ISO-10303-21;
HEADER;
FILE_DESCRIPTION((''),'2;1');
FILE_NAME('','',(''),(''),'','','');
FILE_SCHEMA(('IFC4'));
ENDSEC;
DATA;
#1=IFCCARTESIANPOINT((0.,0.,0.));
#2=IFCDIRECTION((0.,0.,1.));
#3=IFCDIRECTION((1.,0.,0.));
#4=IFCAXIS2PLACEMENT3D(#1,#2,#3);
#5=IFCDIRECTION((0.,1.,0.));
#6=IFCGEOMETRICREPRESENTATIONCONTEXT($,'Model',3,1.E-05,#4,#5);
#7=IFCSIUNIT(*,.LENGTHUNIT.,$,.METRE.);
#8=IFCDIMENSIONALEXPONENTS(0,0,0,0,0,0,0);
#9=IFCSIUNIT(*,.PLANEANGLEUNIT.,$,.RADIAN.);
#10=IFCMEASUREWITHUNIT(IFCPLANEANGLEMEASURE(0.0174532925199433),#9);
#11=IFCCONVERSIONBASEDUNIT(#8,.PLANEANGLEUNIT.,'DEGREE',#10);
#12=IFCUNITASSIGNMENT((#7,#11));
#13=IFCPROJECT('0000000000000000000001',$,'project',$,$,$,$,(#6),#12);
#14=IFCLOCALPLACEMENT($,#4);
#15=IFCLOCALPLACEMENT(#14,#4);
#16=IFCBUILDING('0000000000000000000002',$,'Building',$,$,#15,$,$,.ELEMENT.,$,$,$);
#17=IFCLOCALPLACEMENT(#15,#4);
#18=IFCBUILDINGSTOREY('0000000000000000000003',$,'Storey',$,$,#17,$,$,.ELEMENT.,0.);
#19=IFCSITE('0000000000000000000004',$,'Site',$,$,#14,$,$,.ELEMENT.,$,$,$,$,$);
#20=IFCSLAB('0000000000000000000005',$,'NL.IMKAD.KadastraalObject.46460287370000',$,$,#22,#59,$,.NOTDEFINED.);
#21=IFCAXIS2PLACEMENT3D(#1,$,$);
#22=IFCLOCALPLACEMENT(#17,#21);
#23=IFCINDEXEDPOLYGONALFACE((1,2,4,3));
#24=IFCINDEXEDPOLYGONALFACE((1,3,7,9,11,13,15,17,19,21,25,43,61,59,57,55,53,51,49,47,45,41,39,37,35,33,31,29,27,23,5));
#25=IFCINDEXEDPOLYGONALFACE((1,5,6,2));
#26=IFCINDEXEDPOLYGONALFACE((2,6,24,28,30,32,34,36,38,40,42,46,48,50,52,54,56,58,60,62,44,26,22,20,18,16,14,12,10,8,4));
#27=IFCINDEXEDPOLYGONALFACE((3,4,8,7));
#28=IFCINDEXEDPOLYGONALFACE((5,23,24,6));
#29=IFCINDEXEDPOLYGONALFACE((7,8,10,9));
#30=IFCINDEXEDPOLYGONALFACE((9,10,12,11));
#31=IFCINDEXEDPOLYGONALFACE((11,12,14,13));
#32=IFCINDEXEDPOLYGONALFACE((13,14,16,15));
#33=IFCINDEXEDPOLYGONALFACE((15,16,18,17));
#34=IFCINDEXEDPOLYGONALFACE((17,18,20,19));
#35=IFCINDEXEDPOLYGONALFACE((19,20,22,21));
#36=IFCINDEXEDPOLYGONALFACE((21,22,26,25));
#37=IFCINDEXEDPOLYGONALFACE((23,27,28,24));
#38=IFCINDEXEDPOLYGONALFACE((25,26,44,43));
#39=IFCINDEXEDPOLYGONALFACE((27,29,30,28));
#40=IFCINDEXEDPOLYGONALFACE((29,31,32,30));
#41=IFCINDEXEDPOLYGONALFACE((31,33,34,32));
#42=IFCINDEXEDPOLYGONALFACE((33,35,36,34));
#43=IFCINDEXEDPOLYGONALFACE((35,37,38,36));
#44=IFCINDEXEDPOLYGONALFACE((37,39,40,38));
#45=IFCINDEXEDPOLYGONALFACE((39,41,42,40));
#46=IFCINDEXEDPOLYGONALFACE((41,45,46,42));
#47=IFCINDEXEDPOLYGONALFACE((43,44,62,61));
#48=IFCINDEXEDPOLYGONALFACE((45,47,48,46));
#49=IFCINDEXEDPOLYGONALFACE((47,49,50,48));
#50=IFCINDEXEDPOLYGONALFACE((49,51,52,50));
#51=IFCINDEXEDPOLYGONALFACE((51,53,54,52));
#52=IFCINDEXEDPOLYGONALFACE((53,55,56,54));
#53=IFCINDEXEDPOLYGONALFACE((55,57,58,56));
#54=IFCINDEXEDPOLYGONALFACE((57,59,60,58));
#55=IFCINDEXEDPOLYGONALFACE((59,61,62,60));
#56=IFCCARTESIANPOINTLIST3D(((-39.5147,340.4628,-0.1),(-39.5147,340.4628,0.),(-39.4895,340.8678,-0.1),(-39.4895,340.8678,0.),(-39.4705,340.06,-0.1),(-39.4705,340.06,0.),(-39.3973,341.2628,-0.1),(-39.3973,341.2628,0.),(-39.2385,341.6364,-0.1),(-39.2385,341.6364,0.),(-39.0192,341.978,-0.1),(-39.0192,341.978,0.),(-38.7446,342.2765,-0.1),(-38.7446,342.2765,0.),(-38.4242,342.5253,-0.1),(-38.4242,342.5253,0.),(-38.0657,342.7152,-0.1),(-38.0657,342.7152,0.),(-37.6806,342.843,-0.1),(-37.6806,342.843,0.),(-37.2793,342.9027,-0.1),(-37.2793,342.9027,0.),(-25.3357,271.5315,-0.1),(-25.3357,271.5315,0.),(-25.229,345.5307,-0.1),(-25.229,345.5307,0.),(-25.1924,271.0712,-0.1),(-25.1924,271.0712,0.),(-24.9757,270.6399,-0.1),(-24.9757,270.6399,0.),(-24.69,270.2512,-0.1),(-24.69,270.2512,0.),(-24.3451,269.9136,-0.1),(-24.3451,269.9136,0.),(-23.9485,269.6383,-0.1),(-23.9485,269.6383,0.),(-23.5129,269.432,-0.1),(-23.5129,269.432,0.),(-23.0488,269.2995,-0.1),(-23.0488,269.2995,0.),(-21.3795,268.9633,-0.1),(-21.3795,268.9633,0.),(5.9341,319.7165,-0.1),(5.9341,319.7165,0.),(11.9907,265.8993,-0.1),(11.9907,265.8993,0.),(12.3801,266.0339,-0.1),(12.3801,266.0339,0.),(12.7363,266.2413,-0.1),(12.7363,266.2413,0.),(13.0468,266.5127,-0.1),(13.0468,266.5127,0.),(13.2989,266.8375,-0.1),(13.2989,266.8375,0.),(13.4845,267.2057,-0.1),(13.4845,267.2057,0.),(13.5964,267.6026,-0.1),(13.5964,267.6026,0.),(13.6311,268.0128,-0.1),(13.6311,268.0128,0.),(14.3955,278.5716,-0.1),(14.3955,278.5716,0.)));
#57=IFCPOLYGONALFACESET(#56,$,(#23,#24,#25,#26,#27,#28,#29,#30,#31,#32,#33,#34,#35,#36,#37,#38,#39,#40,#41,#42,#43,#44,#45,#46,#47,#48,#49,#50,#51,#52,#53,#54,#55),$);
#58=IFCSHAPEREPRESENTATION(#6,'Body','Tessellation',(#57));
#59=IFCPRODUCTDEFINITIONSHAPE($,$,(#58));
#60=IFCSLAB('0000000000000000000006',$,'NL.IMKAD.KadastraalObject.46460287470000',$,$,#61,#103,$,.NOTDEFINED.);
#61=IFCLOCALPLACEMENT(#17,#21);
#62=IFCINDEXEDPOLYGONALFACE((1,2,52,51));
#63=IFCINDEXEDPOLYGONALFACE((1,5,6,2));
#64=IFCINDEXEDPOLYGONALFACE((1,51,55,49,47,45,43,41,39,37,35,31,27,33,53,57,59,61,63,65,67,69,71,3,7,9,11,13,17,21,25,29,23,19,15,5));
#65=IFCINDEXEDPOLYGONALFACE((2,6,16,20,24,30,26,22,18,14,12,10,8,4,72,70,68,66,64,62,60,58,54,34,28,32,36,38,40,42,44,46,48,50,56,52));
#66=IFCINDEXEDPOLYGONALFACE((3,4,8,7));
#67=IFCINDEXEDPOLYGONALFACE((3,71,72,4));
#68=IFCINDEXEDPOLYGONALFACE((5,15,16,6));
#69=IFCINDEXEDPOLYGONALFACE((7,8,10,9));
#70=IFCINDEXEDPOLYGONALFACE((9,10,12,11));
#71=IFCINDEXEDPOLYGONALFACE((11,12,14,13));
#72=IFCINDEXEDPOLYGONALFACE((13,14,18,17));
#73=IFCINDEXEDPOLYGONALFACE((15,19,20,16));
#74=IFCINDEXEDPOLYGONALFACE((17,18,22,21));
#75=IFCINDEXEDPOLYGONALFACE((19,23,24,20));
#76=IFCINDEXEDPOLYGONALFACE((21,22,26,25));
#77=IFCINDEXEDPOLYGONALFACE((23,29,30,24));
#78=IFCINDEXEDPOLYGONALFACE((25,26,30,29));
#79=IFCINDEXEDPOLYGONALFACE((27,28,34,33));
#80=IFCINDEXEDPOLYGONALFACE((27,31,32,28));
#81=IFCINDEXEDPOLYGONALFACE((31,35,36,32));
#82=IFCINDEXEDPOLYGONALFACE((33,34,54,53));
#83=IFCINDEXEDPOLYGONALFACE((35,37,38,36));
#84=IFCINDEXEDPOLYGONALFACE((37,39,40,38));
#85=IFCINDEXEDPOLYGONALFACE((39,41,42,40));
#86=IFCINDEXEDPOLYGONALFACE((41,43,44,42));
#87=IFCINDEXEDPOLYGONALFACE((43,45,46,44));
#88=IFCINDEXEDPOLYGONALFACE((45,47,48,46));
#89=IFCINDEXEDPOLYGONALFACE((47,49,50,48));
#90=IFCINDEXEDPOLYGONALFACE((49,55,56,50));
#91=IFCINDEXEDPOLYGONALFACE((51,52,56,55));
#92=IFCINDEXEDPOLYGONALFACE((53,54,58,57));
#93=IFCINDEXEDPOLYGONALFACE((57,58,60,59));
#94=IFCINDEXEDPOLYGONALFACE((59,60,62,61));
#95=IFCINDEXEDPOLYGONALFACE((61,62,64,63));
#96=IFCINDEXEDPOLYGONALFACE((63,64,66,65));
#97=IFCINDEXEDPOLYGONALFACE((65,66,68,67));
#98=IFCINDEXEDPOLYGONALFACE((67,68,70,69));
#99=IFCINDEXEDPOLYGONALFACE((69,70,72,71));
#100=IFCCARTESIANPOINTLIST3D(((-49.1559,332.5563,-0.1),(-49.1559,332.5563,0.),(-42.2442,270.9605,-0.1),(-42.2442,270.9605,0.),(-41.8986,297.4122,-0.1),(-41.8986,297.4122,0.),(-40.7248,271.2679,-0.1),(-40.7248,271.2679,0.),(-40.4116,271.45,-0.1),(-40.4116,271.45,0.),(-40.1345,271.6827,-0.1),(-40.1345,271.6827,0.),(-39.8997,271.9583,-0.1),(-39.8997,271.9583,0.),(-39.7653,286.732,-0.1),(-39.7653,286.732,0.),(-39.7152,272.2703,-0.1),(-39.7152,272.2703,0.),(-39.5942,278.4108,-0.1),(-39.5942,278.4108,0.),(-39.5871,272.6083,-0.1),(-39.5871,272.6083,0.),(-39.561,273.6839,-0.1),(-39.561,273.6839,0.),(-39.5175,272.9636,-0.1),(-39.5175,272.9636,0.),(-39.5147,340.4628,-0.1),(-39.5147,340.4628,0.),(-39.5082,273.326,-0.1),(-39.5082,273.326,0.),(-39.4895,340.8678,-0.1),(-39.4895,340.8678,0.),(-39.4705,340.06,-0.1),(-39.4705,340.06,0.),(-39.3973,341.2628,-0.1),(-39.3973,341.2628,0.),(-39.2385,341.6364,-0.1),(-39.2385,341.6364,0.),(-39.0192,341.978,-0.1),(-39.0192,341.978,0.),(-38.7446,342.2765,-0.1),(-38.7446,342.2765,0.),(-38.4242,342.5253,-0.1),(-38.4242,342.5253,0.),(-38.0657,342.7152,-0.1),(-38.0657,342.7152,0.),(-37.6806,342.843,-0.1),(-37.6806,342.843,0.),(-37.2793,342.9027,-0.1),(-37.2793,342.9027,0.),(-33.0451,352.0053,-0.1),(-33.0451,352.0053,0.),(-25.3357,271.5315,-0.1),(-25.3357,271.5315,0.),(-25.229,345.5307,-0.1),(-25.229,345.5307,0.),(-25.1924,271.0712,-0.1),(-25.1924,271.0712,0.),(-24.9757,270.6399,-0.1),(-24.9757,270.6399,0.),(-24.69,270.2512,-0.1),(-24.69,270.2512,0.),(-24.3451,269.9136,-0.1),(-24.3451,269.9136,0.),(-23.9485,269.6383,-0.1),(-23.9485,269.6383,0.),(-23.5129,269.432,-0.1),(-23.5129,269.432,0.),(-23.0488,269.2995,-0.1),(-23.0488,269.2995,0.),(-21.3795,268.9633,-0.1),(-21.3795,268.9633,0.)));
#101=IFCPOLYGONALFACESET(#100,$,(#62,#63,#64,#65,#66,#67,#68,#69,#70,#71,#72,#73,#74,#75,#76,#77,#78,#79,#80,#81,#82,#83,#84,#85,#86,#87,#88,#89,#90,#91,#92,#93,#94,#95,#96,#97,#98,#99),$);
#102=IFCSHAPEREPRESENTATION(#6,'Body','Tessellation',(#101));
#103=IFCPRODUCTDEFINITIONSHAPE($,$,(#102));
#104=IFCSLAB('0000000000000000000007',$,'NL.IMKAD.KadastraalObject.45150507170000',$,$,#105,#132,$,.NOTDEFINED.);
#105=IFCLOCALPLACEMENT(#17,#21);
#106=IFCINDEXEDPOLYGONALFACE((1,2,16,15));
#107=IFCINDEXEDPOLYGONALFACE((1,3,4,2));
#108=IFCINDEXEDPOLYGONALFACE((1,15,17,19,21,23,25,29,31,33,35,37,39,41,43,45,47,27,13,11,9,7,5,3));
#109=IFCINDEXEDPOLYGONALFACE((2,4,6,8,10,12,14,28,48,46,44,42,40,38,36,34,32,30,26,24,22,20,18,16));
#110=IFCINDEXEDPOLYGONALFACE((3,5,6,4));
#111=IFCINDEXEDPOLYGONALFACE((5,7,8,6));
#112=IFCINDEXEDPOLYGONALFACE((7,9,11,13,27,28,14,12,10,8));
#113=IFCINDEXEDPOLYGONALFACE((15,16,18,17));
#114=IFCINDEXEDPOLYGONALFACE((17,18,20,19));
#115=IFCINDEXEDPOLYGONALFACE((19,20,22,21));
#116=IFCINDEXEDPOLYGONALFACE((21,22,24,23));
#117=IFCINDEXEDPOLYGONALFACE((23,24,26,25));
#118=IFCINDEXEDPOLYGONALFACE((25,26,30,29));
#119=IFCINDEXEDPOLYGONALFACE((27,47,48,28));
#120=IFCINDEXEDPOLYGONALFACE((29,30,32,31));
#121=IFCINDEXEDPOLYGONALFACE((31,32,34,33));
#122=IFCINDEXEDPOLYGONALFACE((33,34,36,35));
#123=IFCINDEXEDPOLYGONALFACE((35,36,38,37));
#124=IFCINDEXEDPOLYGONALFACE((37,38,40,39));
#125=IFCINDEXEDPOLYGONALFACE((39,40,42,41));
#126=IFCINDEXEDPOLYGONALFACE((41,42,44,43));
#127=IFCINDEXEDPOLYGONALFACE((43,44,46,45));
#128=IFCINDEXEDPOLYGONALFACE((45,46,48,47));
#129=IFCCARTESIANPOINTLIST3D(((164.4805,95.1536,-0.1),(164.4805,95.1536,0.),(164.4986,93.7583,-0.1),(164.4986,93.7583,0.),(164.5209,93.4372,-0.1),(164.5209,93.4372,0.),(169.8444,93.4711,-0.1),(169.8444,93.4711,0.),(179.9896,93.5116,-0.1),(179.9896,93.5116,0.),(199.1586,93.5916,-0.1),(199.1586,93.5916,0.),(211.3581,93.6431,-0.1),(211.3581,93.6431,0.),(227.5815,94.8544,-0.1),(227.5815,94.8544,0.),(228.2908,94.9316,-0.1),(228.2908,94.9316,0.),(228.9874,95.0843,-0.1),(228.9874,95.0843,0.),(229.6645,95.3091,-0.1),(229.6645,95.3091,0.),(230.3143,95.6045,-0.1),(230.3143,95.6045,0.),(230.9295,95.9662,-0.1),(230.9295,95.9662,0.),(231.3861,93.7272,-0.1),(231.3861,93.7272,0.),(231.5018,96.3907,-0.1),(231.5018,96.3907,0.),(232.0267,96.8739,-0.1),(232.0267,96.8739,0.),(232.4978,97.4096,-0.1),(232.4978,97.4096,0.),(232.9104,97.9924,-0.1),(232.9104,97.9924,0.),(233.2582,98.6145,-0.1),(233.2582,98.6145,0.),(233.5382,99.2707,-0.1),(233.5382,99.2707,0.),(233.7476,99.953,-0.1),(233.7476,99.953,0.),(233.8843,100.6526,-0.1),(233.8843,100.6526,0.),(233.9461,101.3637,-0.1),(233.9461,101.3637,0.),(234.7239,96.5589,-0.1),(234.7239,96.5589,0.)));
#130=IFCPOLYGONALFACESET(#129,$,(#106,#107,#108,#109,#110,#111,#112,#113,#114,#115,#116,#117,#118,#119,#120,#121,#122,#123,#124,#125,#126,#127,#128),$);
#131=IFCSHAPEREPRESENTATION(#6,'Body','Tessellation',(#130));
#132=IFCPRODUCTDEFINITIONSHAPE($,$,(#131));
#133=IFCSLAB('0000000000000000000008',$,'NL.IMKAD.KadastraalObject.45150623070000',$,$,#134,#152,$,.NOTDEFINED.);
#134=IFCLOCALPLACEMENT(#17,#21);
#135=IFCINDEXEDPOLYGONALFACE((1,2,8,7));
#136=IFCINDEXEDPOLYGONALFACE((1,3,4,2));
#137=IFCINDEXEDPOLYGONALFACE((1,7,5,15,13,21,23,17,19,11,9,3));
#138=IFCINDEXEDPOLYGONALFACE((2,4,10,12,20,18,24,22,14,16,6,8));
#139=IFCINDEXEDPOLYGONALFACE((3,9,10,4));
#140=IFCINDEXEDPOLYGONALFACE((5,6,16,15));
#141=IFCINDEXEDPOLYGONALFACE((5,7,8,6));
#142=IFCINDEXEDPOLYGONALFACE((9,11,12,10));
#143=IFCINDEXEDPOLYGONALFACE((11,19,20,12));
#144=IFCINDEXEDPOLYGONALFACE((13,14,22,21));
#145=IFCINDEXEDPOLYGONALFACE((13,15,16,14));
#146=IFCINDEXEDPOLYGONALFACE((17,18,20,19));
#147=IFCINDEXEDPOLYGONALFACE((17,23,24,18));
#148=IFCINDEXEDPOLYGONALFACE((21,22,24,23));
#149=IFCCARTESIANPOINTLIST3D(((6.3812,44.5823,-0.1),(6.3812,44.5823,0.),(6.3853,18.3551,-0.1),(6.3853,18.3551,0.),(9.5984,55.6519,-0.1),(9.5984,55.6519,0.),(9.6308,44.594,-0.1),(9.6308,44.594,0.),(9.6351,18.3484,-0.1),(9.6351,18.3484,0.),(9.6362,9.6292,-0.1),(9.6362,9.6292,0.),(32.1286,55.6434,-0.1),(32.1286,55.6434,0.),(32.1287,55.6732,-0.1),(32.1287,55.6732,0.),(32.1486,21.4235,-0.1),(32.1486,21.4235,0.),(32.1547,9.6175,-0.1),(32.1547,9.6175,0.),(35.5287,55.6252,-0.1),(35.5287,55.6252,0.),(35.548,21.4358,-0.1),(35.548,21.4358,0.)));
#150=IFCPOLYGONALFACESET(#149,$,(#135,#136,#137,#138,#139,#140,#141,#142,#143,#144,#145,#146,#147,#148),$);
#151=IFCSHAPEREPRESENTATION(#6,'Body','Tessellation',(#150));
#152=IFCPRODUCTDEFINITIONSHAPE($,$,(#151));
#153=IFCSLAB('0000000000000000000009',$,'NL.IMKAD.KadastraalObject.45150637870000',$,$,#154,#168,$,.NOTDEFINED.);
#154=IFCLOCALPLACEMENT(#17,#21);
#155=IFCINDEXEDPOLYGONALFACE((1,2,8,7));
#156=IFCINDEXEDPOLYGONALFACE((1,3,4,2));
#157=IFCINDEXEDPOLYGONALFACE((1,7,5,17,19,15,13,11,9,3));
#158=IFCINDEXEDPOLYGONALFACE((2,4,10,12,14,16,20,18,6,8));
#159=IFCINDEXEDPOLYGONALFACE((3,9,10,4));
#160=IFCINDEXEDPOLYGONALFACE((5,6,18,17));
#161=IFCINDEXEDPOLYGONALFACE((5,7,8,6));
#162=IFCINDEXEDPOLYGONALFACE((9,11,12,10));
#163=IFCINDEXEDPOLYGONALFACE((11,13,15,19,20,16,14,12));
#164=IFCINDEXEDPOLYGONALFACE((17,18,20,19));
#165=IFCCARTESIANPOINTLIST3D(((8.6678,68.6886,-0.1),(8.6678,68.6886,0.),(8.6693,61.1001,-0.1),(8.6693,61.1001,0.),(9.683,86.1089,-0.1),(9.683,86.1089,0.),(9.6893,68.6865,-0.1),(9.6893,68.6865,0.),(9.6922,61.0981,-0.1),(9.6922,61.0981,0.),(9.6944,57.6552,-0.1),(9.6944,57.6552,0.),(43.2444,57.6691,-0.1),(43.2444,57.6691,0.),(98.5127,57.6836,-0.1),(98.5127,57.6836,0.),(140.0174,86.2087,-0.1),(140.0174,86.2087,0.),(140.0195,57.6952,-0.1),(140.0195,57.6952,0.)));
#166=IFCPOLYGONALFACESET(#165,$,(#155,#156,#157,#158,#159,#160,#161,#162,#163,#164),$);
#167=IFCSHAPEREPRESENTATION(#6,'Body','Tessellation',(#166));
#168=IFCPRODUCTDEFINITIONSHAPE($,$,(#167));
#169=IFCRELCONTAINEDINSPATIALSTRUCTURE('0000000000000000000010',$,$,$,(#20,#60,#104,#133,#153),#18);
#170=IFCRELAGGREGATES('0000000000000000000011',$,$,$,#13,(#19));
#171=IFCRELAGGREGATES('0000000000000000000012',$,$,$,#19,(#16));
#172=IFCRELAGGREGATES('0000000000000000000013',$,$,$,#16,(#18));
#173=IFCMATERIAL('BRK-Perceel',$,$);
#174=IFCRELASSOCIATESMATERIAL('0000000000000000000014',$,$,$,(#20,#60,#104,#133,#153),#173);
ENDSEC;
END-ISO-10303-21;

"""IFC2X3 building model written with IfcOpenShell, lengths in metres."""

from ifc_helpers import new_model, entity, si_unit, converted_unit, direction, frame, origin_with_axes, place, context, project, spatial, polyline, outline, extrude, material, element, save


model = new_model("IFC2X3")

# Units and contexts
model_context = context("Model", 3, precision=1e-05, world=origin_with_axes(), true_north=direction((0.0, 1.0, 0.0)))
ifc_project = project(units=[si_unit("LENGTHUNIT", "METRE"), converted_unit("PLANEANGLEUNIT", "DEGREE", entity("IfcPlaneAngleMeasure", 0.0174532925199433), si_unit("PLANEANGLEUNIT", "RADIAN"), dimensions=[0, 0, 0, 0, 0, 0, 0])], contexts=[model_context])

# Site, building, storey
site_placement = place(None, origin_with_axes())
site = spatial("IfcSite", under=ifc_project, at=site_placement, Name="Site", CompositionType="ELEMENT")
building_placement = place(site_placement, origin_with_axes())
building = spatial("IfcBuilding", under=site, at=building_placement, Name="Building", CompositionType="ELEMENT")
storey_placement = place(building_placement, origin_with_axes())
storey = spatial("IfcBuildingStorey", under=building, at=storey_placement, Name="Storey", CompositionType="ELEMENT", Elevation=0.0)

# Slabs
ifc_material = material(Name="BRK-Perceel")
slab_1_placement = place(storey_placement, frame((0.0, 0.0, -0.1), z_axis=(0.0, 0.0, 1.0), x_axis=(1.0, 0.0, 0.0)))
element("IfcSlab", 1, at=slab_1_placement, inside=storey, material=ifc_material, Name="NL.IMKAD.KadastraalObject.46460287370000", PredefinedType="NOTDEFINED", context=model_context, shape_type="SweptSolid", body=[
    extrude(outline(polyline([(14.3955, 278.5716), (13.6311, 268.0128), (13.5964, 267.6026), (13.4845, 267.2057), (13.2989, 266.8375), (13.0468, 266.5127), (12.7363, 266.2413), (12.3801, 266.0339), (11.9907, 265.8993), (-21.3795, 268.9633), (-23.0488, 269.2995), (-23.5129, 269.432), (-23.9485, 269.6383), (-24.3451, 269.9136), (-24.69, 270.2512), (-24.9757, 270.6399), (-25.1924, 271.0712), (-25.3357, 271.5315), (-39.4705, 340.06), (-39.5147, 340.4628), (-39.4895, 340.8678), (-39.3973, 341.2628), (-39.2385, 341.6364), (-39.0192, 341.978), (-38.7446, 342.2765), (-38.4242, 342.5253), (-38.0657, 342.7152), (-37.6806, 342.843), (-37.2793, 342.9027), (-25.229, 345.5307), (5.9341, 319.7165), (14.3955, 278.5716)])), origin_with_axes(), (0.0, 0.0, 1.0), 0.1),
])
slab_2_placement = place(storey_placement, frame((0.0, 0.0, -0.1), z_axis=(0.0, 0.0, 1.0), x_axis=(1.0, 0.0, 0.0)))
element("IfcSlab", 2, at=slab_2_placement, inside=storey, material=ifc_material, Name="NL.IMKAD.KadastraalObject.46460287470000", PredefinedType="NOTDEFINED", context=model_context, shape_type="SweptSolid", body=[
    extrude(outline(polyline([(-37.2793, 342.9027), (-37.6806, 342.843), (-38.0657, 342.7152), (-38.4242, 342.5253), (-38.7446, 342.2765), (-39.0192, 341.978), (-39.2385, 341.6364), (-39.3973, 341.2628), (-39.4895, 340.8678), (-39.5147, 340.4628), (-39.4705, 340.06), (-25.3357, 271.5315), (-25.1924, 271.0712), (-24.9757, 270.6399), (-24.69, 270.2512), (-24.3451, 269.9136), (-23.9485, 269.6383), (-23.5129, 269.432), (-23.0488, 269.2995), (-21.3795, 268.9633), (-42.2442, 270.9605), (-40.7248, 271.2679), (-40.4116, 271.45), (-40.1345, 271.6827), (-39.8997, 271.9583), (-39.7152, 272.2703), (-39.5871, 272.6083), (-39.5175, 272.9636), (-39.5082, 273.326), (-39.561, 273.6839), (-39.5942, 278.4108), (-39.7653, 286.732), (-41.8986, 297.4122), (-49.1559, 332.5563), (-33.0451, 352.0053), (-25.229, 345.5307), (-37.2793, 342.9027)])), origin_with_axes(), (0.0, 0.0, 1.0), 0.1),
])
slab_3_placement = place(storey_placement, frame((0.0, 0.0, -0.1), z_axis=(0.0, 0.0, 1.0), x_axis=(1.0, 0.0, 0.0)))
element("IfcSlab", 3, at=slab_3_placement, inside=storey, material=ifc_material, Name="NL.IMKAD.KadastraalObject.45150507170000", PredefinedType="NOTDEFINED", context=model_context, shape_type="SweptSolid", body=[
    extrude(outline(polyline([(228.2908, 94.9316), (228.9874, 95.0843), (229.6645, 95.3091), (230.3143, 95.6045), (230.9295, 95.9662), (231.5018, 96.3907), (232.0267, 96.8739), (232.4978, 97.4096), (232.9104, 97.9924), (233.2582, 98.6145), (233.5382, 99.2707), (233.7476, 99.953), (233.8843, 100.6526), (233.9461, 101.3637), (234.7239, 96.5589), (231.3861, 93.7272), (211.3581, 93.6431), (199.1586, 93.5916), (179.9896, 93.5116), (169.8444, 93.4711), (164.5209, 93.4372), (164.4986, 93.7583), (164.4805, 95.1536), (227.5815, 94.8544), (228.2908, 94.9316)])), origin_with_axes(), (0.0, 0.0, 1.0), 0.1),
])
slab_4_placement = place(storey_placement, frame((0.0, 0.0, -0.1), z_axis=(0.0, 0.0, 1.0), x_axis=(1.0, 0.0, 0.0)))
element("IfcSlab", 4, at=slab_4_placement, inside=storey, material=ifc_material, Name="NL.IMKAD.KadastraalObject.45150623070000", PredefinedType="NOTDEFINED", context=model_context, shape_type="SweptSolid", body=[
    extrude(outline(polyline([(9.6362, 9.6292), (9.6351, 18.3484), (6.3853, 18.3551), (6.3812, 44.5823), (9.6308, 44.594), (9.5984, 55.6519), (32.1287, 55.6732), (32.1286, 55.6434), (35.5287, 55.6252), (35.548, 21.4358), (32.1486, 21.4235), (32.1547, 9.6175), (9.6362, 9.6292)])), origin_with_axes(), (0.0, 0.0, 1.0), 0.1),
])
slab_5_placement = place(storey_placement, frame((0.0, 0.0, -0.1), z_axis=(0.0, 0.0, 1.0), x_axis=(1.0, 0.0, 0.0)))
element("IfcSlab", 5, at=slab_5_placement, inside=storey, material=ifc_material, Name="NL.IMKAD.KadastraalObject.45150637870000", PredefinedType="NOTDEFINED", context=model_context, shape_type="SweptSolid", body=[
    extrude(outline(polyline([(98.5127, 57.6836), (43.2444, 57.6691), (9.6944, 57.6552), (9.6922, 61.0981), (8.6693, 61.1001), (8.6678, 68.6886), (9.6893, 68.6865), (9.683, 86.1089), (140.0174, 86.2087), (140.0195, 57.6952), (98.5127, 57.6836)])), origin_with_axes(), (0.0, 0.0, 1.0), 0.1),
])

save(model, "model.ifc")
